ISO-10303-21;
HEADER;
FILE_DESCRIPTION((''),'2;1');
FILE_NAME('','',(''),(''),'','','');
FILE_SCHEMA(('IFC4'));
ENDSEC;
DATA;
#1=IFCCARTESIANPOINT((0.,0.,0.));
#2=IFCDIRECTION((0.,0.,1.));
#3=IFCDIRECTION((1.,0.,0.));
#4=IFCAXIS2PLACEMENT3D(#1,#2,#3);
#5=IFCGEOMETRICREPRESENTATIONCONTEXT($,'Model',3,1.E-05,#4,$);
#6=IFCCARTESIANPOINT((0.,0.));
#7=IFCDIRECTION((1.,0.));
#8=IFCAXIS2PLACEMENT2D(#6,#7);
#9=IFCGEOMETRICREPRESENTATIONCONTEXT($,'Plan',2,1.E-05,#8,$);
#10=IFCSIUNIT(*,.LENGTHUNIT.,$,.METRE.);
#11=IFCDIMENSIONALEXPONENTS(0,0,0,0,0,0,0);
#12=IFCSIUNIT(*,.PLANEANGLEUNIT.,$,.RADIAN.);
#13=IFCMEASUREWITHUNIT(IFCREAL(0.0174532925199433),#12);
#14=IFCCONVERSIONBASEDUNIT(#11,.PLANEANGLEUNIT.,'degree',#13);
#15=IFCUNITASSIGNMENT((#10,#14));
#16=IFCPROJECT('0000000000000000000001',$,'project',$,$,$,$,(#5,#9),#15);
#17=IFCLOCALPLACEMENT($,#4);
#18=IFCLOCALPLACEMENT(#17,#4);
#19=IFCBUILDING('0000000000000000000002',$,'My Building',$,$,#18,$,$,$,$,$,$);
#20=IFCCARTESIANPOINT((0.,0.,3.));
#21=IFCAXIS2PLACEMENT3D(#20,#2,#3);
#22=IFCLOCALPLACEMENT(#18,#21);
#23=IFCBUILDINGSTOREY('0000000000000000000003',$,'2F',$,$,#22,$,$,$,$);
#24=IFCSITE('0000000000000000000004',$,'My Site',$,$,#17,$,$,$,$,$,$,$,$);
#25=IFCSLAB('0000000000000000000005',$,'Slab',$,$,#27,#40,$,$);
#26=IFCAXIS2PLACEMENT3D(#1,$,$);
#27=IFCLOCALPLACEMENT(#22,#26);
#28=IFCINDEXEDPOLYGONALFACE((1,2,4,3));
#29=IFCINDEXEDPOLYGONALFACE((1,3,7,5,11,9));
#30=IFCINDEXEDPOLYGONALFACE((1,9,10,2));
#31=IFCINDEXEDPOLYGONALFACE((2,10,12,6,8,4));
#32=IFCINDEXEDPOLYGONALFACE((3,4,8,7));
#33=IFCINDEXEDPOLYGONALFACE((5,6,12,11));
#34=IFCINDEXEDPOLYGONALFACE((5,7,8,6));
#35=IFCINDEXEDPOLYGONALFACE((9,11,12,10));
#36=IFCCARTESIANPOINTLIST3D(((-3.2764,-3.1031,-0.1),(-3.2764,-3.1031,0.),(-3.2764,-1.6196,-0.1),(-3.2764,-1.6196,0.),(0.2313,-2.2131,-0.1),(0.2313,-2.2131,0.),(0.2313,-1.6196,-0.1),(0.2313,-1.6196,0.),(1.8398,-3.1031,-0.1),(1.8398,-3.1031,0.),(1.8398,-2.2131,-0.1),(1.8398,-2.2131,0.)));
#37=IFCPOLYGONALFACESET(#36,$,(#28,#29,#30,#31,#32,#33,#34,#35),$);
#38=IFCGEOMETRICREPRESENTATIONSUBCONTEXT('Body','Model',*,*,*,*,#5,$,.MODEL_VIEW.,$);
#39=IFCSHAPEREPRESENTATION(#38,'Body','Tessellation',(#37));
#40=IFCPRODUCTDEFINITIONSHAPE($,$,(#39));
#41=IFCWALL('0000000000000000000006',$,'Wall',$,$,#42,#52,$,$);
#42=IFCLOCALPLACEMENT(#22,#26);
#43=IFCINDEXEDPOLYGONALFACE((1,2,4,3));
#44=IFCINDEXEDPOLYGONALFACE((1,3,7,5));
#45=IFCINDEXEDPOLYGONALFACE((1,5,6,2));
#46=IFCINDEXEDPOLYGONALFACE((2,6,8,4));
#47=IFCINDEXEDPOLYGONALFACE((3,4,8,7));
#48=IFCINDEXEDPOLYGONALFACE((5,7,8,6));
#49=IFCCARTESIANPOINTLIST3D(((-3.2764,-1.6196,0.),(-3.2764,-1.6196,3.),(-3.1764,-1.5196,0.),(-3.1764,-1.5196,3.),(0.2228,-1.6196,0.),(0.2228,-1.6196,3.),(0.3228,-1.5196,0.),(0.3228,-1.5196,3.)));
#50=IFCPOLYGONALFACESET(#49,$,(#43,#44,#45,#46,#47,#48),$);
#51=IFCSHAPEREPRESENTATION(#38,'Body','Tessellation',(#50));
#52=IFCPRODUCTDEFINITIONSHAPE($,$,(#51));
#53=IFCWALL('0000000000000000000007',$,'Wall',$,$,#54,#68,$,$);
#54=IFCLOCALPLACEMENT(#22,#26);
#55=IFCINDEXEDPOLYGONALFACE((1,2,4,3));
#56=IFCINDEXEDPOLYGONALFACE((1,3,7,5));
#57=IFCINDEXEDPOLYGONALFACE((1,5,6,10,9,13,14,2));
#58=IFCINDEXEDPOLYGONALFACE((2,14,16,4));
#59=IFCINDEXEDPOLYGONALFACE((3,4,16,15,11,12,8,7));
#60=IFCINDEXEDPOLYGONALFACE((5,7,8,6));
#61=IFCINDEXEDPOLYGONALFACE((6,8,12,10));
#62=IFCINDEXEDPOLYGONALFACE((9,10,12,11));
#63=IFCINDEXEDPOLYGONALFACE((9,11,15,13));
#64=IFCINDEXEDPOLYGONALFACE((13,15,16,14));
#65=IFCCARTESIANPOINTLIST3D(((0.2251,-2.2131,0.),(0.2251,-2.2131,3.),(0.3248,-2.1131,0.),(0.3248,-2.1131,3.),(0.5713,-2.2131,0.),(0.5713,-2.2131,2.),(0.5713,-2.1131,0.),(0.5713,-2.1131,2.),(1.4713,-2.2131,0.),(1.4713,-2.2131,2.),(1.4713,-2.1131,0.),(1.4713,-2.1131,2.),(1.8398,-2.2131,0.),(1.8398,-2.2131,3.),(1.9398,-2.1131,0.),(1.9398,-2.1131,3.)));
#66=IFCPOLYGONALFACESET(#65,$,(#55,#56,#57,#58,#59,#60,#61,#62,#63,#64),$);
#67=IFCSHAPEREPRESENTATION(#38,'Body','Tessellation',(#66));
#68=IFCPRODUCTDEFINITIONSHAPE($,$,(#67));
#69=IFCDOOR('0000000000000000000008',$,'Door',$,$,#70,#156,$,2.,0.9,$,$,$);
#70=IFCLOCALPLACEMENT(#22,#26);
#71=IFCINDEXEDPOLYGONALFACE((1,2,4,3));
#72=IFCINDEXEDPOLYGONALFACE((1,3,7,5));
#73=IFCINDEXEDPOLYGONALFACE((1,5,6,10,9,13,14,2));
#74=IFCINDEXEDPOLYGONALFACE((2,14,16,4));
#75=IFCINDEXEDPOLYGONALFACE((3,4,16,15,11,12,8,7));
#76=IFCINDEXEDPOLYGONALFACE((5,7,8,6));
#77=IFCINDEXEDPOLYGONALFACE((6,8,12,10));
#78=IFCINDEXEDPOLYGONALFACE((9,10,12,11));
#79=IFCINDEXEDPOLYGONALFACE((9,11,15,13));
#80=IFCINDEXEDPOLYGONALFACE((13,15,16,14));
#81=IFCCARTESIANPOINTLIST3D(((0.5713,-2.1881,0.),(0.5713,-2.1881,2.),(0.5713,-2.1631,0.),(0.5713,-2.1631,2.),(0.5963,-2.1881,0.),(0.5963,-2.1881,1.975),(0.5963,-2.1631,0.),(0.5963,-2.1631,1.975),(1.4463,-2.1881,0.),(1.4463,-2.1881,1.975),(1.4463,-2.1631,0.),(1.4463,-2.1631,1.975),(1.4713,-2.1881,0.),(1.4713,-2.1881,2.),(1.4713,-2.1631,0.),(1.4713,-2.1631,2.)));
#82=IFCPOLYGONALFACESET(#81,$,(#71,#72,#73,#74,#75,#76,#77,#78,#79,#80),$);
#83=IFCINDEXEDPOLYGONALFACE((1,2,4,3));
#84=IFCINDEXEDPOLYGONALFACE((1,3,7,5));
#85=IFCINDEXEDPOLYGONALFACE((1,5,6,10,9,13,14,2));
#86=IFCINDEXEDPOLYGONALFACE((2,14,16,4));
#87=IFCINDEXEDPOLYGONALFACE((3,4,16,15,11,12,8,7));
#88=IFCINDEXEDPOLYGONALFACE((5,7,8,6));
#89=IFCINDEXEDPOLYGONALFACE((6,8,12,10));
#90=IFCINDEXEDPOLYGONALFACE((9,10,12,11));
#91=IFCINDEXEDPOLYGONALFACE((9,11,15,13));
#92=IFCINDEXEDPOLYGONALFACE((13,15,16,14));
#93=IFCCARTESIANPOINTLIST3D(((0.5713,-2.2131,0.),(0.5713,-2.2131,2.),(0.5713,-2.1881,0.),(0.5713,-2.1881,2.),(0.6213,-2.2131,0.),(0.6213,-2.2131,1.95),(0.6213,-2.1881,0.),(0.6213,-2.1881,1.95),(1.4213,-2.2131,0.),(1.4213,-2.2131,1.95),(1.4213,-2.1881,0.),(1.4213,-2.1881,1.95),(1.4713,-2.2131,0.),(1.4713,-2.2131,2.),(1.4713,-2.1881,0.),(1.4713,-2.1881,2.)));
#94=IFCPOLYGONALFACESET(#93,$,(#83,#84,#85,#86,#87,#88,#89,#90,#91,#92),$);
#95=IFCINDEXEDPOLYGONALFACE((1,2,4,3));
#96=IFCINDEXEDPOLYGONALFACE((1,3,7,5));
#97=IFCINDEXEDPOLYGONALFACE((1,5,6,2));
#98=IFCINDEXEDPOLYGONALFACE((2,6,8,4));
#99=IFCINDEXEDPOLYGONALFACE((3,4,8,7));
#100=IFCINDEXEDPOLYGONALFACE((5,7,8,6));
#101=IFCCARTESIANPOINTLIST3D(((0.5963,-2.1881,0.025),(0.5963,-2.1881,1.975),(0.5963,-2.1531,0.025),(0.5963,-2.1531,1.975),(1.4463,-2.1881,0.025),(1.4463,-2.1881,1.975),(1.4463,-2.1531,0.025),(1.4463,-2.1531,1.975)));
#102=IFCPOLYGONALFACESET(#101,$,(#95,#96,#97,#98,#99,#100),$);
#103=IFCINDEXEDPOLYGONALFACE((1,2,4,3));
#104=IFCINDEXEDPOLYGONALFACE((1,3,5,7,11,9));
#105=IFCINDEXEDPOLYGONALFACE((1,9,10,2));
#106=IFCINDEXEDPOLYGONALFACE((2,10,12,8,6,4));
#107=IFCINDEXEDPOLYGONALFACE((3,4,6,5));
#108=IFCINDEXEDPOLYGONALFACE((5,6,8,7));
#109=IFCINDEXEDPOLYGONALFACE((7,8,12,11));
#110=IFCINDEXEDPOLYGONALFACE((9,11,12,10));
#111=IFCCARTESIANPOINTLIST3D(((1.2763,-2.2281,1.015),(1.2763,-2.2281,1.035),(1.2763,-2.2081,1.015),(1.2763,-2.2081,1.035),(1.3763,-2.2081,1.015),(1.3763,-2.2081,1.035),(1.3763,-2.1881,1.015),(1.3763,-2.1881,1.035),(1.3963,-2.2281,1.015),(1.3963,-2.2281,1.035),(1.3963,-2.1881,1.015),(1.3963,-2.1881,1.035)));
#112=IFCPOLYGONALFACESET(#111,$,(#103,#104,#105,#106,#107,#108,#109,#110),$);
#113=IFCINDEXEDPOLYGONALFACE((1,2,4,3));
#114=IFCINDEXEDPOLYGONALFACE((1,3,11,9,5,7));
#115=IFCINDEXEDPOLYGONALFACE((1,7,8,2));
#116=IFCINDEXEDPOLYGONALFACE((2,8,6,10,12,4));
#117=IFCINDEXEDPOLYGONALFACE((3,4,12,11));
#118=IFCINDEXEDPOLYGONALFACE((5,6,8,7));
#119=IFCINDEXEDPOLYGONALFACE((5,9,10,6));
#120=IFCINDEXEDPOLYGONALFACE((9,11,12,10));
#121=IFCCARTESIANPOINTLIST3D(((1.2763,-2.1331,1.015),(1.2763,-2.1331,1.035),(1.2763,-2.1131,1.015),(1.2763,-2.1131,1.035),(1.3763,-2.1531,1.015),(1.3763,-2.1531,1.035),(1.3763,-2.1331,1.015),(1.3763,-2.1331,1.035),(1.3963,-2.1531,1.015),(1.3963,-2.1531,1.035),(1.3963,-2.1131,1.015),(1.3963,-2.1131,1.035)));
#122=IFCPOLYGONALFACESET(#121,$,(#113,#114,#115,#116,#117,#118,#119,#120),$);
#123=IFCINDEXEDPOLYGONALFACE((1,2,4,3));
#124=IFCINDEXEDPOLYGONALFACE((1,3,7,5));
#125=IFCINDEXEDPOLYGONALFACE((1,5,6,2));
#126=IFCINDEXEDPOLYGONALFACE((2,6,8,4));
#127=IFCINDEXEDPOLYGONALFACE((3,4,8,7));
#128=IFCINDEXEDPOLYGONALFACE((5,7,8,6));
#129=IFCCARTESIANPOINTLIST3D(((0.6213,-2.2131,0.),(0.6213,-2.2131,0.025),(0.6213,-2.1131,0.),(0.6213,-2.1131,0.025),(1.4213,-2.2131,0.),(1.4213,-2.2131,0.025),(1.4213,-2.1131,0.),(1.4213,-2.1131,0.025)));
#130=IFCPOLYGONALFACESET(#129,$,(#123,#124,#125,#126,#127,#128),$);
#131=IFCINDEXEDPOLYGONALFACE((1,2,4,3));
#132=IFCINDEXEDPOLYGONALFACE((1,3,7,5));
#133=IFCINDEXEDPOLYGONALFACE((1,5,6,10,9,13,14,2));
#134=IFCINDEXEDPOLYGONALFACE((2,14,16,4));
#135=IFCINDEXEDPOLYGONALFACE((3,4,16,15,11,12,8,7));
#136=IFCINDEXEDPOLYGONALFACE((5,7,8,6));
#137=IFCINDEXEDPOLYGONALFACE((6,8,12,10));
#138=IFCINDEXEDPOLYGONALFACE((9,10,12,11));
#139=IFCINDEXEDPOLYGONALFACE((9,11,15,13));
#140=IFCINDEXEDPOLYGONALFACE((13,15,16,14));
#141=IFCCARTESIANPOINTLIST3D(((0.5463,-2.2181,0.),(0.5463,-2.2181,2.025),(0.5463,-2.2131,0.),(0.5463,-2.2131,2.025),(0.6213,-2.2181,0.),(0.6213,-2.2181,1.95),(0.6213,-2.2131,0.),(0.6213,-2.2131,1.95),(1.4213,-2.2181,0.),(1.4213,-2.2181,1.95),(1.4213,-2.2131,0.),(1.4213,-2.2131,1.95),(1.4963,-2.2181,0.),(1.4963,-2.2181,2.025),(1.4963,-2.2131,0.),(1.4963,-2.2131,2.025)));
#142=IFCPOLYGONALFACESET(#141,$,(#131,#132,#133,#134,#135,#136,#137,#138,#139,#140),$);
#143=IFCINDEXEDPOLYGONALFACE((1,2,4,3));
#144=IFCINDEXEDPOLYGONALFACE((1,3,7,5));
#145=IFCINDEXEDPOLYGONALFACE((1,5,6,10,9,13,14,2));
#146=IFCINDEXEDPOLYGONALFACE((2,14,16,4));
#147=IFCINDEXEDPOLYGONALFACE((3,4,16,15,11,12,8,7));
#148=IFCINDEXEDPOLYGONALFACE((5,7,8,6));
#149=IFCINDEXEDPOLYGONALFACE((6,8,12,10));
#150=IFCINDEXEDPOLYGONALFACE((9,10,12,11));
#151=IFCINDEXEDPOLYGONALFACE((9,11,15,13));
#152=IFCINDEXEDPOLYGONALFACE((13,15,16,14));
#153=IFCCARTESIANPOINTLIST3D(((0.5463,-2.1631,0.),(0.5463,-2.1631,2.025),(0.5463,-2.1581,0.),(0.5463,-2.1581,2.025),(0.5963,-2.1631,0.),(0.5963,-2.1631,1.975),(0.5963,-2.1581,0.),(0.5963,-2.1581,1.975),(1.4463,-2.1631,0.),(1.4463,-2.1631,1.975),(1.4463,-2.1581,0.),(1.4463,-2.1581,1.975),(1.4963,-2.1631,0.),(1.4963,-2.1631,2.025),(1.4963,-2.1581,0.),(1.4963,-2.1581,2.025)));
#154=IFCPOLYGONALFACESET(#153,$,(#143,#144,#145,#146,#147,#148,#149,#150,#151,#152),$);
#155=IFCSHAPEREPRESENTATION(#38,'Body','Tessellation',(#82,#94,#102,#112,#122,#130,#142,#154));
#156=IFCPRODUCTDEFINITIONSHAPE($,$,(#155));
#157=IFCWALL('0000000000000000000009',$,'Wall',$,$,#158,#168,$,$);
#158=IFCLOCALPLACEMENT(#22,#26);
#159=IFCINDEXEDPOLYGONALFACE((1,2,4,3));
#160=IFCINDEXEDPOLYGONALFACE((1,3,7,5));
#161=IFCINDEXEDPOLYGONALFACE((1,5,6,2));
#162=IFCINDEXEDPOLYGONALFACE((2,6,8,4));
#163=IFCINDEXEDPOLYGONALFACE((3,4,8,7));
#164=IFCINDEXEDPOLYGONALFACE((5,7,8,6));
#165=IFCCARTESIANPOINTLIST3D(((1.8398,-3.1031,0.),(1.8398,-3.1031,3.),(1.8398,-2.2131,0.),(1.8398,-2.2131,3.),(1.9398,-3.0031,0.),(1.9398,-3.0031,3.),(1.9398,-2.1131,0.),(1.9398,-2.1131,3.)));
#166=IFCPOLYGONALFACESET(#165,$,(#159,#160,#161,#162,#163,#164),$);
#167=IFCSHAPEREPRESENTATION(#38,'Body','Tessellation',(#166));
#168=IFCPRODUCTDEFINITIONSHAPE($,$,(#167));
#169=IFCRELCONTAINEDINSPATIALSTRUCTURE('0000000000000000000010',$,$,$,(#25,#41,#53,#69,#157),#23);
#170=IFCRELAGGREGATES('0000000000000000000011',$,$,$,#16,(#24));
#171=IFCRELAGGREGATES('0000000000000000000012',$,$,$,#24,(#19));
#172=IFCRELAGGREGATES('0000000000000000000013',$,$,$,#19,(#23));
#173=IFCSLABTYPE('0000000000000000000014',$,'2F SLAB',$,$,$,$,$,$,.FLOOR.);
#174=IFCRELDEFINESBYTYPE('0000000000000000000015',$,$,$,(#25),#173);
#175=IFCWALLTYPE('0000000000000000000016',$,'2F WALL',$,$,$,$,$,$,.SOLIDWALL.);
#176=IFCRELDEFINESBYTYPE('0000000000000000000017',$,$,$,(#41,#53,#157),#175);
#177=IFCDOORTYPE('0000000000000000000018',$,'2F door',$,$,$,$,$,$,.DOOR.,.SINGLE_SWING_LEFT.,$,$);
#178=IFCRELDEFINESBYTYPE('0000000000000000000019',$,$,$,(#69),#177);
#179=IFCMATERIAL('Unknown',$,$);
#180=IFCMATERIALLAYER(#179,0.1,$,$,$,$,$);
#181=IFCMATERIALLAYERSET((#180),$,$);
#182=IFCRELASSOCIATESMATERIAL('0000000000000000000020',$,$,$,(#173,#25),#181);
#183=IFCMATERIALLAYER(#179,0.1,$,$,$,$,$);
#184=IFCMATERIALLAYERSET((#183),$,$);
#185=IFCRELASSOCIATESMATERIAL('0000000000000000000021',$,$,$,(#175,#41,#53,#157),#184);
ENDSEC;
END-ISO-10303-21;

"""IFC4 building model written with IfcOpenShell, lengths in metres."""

from ifc_helpers import new_model, entity, si_unit, converted_unit, frame, origin_with_axes, origin_2d_with_axis, place, context, subcontext, project, spatial, line, indexed_curve, outline, extrude, shape, source, transform, mapped, material, layer, layer_set, layer_usage, type_object, type_shapes, element, fill, save


model = new_model("IFC4")

# Units and contexts
model_context = context("Model", 3, precision=1e-05, world=origin_with_axes())
plan_context = context("Plan", 2, precision=1e-05, world=origin_2d_with_axis())
body_context_1 = subcontext(model_context, "Body", "Model", "MODEL_VIEW")
body_context_2 = subcontext(plan_context, "Body", "Plan", "PLAN_VIEW")
ifc_project = project(units=[si_unit("LENGTHUNIT", "METRE"), converted_unit("PLANEANGLEUNIT", "degree", entity("IfcReal", 0.0174532925199433), si_unit("PLANEANGLEUNIT", "RADIAN"), dimensions=[0, 0, 0, 0, 0, 0, 0])], contexts=[model_context, plan_context])

# Site, building, storey
site_placement = place(None, origin_with_axes())
site = spatial("IfcSite", under=ifc_project, at=site_placement, Name="My Site")
building_placement = place(site_placement, origin_with_axes())
building = spatial("IfcBuilding", under=site, at=building_placement, Name="My Building")
storey_placement = place(building_placement, frame((0.0, 0.0, 3.0), z_axis=(0.0, 0.0, 1.0), x_axis=(1.0, 0.0, 0.0)))
storey = spatial("IfcBuildingStorey", under=building, at=storey_placement, Name="2F")

# Slab
ifc_material = material(Name="Unknown")
ifc_layer_1 = layer(ifc_material, 0.1)
ifc_layer_set_1 = layer_set([ifc_layer_1])
ifc_layer_usage_1 = layer_usage(ifc_layer_set_1, "AXIS3", "POSITIVE", -0.1)
slab_type = type_object("IfcSlabType", Name="2F SLAB", PredefinedType="FLOOR", material=ifc_layer_set_1)
slab_placement = place(storey_placement, frame((1.8398, -3.1031, 0.0), z_axis=(0.0, 0.0, 1.0), x_axis=(1.0, 0.0, 0.0)))
element("IfcSlab", 1, at=slab_placement, inside=storey, type_object=slab_type, material=ifc_layer_usage_1, Name="Slab", context=body_context_1, shape_type="SweptSolid", body=[
    extrude(outline(indexed_curve([(0.0, 0.0), (-5.1163, 0.0), (-5.1163, 1.4834), (-1.6085, 1.4834), (-1.6085, 0.89), (0.0, 0.89), (0.0, 0.0)])), frame((0.0, 0.0, -0.1), z_axis=(0.0, 0.0, 1.0), x_axis=(1.0, 0.0, 0.0)), (0.0, 0.0, 1.0), 0.1),
])

# Wall
ifc_layer_2 = layer(ifc_material, 0.1)
ifc_layer_set_2 = layer_set([ifc_layer_2])
ifc_layer_usage_2 = layer_usage(ifc_layer_set_2, "AXIS2", "POSITIVE", 0.0)
wall_type = type_object("IfcWallType", Name="2F WALL", PredefinedType="SOLIDWALL", material=ifc_layer_set_2)
wall_1_placement = place(storey_placement, frame((-3.2764, -1.6196, 0.0), z_axis=(0.0, 0.0, 1.0), x_axis=(1.0, 0.0, 0.0)))
element("IfcWall", 2, at=wall_1_placement, inside=storey, type_object=wall_type, material=ifc_layer_usage_2, Name="Wall", context=body_context_1, shape_type="SweptSolid", body=[
    extrude(outline(indexed_curve([(0.0, 0.0), (0.1, 0.1), (3.5993, 0.1), (3.4993, 0.0)], segments=[line(1, 2, 3, 4, 1)])), origin_with_axes(), (0.0, 0.0, 1.0), 3.0),
])

# Wall, opening, door
ifc_layer_usage_3 = layer_usage(ifc_layer_set_2, "AXIS2", "POSITIVE", 0.0)
wall_2_placement = place(storey_placement, frame((0.2251, -2.2131, 0.0), z_axis=(0.0, 0.0, 1.0), x_axis=(1.0, 0.0, 0.0)))
wall_2 = element("IfcWall", 3, at=wall_2_placement, inside=storey, type_object=wall_type, material=ifc_layer_usage_3, Name="Wall", context=body_context_1, shape_type="SweptSolid", body=[
    extrude(outline(indexed_curve([(0.0, 0.0), (0.0996, 0.1), (1.7147, 0.1), (1.6147, 0.0)], segments=[line(1, 2, 3, 4, 1)])), origin_with_axes(), (0.0, 0.0, 1.0), 3.0),
])
shared_shape_1 = source(origin_with_axes(), body_context_1, "Body", "SweptSolid", [
    extrude(outline(indexed_curve([(0.0, 0.0), (0.9, 0.0), (0.9, 2.0), (0.0, 2.0)], segments=[line(1, 2, 3, 4, 1)])), frame((0.0, -0.6, 0.0), z_axis=(0.0, -1.0, 0.0), x_axis=(1.0, 0.0, 0.0)), (0.0, 0.0, -1.0), 1.2),
])
opening_1_placement = place(wall_2_placement, frame((0.3462, 0.0, 0.0), z_axis=(0.0, 0.0, 1.0), x_axis=(1.0, 0.0, 0.0)))
opening_1 = element("IfcOpeningElement", 4, at=opening_1_placement, cuts=wall_2, PredefinedType="OPENING", context=body_context_1, shape_type="MappedRepresentation", body=[
    mapped(shared_shape_1, transform((0.0, 0.0, 0.0), x_axis=(1.0, 0.0, 0.0), y_axis=(0.0, 1.0, 0.0), z_axis=(0.0, 0.0, 1.0), scale=1.0)),
])
door_type = type_object("IfcDoorType", Name="2F door", OperationType="SINGLE_SWING_LEFT", PredefinedType="DOOR")
shared_shape_2 = source(origin_with_axes(), body_context_1, "Body", "SweptSolid", [
    extrude(outline(indexed_curve([(0.0, 0.0), (0.0, 2.0), (0.9, 2.0), (0.9, 0.0), (0.875, 0.0), (0.875, 1.975), (0.025, 1.975), (0.025, 0.0)], segments=[line(1, 2, 3, 4, 5, 6, 7, 8, 1)])), frame((0.0, 0.025, 0.0), z_axis=(0.0, -1.0, 0.0), x_axis=(1.0, 0.0, 0.0)), (0.0, 0.0, -1.0), 0.025),
    extrude(outline(indexed_curve([(0.0, 0.0), (0.0, 2.0), (0.9, 2.0), (0.9, 0.0), (0.85, 0.0), (0.85, 1.95), (0.05, 1.95), (0.05, 0.0)], segments=[line(1, 2, 3, 4, 5, 6, 7, 8, 1)])), frame((0.0, 0.0, 0.0), z_axis=(0.0, -1.0, 0.0), x_axis=(1.0, 0.0, 0.0)), (0.0, 0.0, -1.0), 0.025),
    extrude(outline(indexed_curve([(0.0, 0.0), (0.85, 0.0), (0.85, 0.035), (0.0, 0.035)], segments=[line(1, 2, 3, 4, 1)])), frame((0.025, 0.025, 0.025), z_axis=(0.0, 0.0, 1.0), x_axis=(1.0, 0.0, 0.0)), (0.0, 0.0, 1.0), 1.95),
    extrude(outline(indexed_curve([(0.0, 0.0), (0.0, -0.04), (-0.12, -0.04), (-0.12, -0.02), (-0.02, -0.02), (-0.02, 0.0)], segments=[line(1, 2, 3, 4, 5, 6, 1)])), frame((0.825, 0.025, 1.015), z_axis=(0.0, 0.0, 1.0), x_axis=(1.0, 0.0, 0.0)), (0.0, 0.0, 1.0), 0.02),
    extrude(outline(indexed_curve([(0.0, 0.0), (0.0, 0.04), (-0.12, 0.04), (-0.12, 0.02), (-0.02, 0.02), (-0.02, 0.0)], segments=[line(1, 2, 3, 4, 5, 6, 1)])), frame((0.825, 0.06, 1.015), z_axis=(0.0, 0.0, 1.0), x_axis=(1.0, 0.0, 0.0)), (0.0, 0.0, 1.0), 0.02),
    extrude(outline(indexed_curve([(0.0, 0.0), (0.8, 0.0), (0.8, 0.1), (0.0, 0.1)], segments=[line(1, 2, 3, 4, 1)])), frame((0.05, 0.0, 0.0), z_axis=(0.0, 0.0, 1.0), x_axis=(1.0, 0.0, 0.0)), (0.0, 0.0, 1.0), 0.025),
    extrude(outline(indexed_curve([(0.0, 0.0), (0.0, 2.025), (0.95, 2.025), (0.95, 0.0), (0.875, 0.0), (0.875, 1.95), (0.075, 1.95), (0.075, 0.0)], segments=[line(1, 2, 3, 4, 5, 6, 7, 8, 1)])), frame((-0.025, -0.005, 0.0), z_axis=(0.0, -1.0, 0.0), x_axis=(1.0, 0.0, 0.0)), (0.0, 0.0, -1.0), 0.005),
    extrude(outline(indexed_curve([(0.0, 0.0), (0.0, 2.025), (0.95, 2.025), (0.95, 0.0), (0.9, 0.0), (0.9, 1.975), (0.05, 1.975), (0.05, 0.0)], segments=[line(1, 2, 3, 4, 5, 6, 7, 8, 1)])), frame((-0.025, 0.05, 0.0), z_axis=(0.0, -1.0, 0.0), x_axis=(1.0, 0.0, 0.0)), (0.0, 0.0, -1.0), 0.005),
])
shared_shape_3 = source(origin_with_axes(), body_context_2, "Body", "Curve2D", [
    entity("IfcIndexedPolyCurve", entity("IfcCartesianPointList2D", [[0.0, 0.0], [0.0, 0.05], [0.025, 0.05], [0.025, 0.025], [0.05, 0.025], [0.05, 0.0]]), [entity("IfcLineIndex", [1, 2, 3, 4, 5, 6, 1])]),
    entity("IfcIndexedPolyCurve", entity("IfcCartesianPointList2D", [[0.9, 0.0], [0.9, 0.05], [0.875, 0.05], [0.875, 0.025], [0.85, 0.025], [0.85, 0.0]]), [entity("IfcLineIndex", [1, 2, 3, 4, 5, 6, 1])]),
    entity("IfcTrimmedCurve", entity("IfcEllipse", entity("IfcAxis2Placement2D", entity("IfcCartesianPoint", [0.06, 0.05]), entity("IfcDirection", [1.0, 0.0])), 0.815, 0.85), [entity("IfcCartesianPoint", [0.875, 0.05])], [entity("IfcCartesianPoint", [0.06, 0.9])], True, "CARTESIAN"),
    entity("IfcIndexedPolyCurve", entity("IfcCartesianPointList2D", [[0.025, 0.05], [0.06, 0.05], [0.06, 0.9], [0.025, 0.9]]), [entity("IfcLineIndex", [1, 2, 3, 4, 1])]),
])
type_shapes(door_type, [shared_shape_2, shared_shape_3])
door_1_placement = place(opening_1_placement, frame((0.0, 0.0, 0.0), z_axis=(0.0, 0.0, 1.0), x_axis=(1.0, 0.0, 0.0)))
door_1 = element("IfcDoor", 5, at=door_1_placement, inside=storey, type_object=door_type, Name="Door", OverallHeight=2.0, OverallWidth=0.9, shapes=[
    shape(body_context_1, "Body", "MappedRepresentation", [mapped(shared_shape_2, transform((0.0, 0.0, 0.0), x_axis=(1.0, 0.0, 0.0), y_axis=(0.0, 1.0, 0.0), z_axis=(0.0, 0.0, 1.0), scale=1.0))]),
    shape(body_context_2, "Body", "MappedRepresentation", [mapped(shared_shape_3, transform((0.0, 0.0, 0.0), x_axis=(1.0, 0.0, 0.0), y_axis=(0.0, 1.0, 0.0), z_axis=(0.0, 0.0, 1.0), scale=1.0))]),
])
fill(opening_1, door_1)

# Wall
ifc_layer_usage_4 = layer_usage(ifc_layer_set_2, "AXIS2", "POSITIVE", 0.0)
wall_3_placement = place(storey_placement, frame((1.8398, -2.2131, 0.0), z_axis=(0.0, 0.0, 1.0), x_axis=(0.0, -1.0, 0.0)))
element("IfcWall", 6, at=wall_3_placement, inside=storey, type_object=wall_type, material=ifc_layer_usage_4, Name="Wall", context=body_context_1, shape_type="SweptSolid", body=[
    extrude(outline(indexed_curve([(0.0, 0.0), (-0.1, 0.1), (0.79, 0.1), (0.89, 0.0)], segments=[line(1, 2, 3, 4, 1)])), origin_with_axes(), (0.0, 0.0, 1.0), 3.0),
])

save(model, "model.ifc")
